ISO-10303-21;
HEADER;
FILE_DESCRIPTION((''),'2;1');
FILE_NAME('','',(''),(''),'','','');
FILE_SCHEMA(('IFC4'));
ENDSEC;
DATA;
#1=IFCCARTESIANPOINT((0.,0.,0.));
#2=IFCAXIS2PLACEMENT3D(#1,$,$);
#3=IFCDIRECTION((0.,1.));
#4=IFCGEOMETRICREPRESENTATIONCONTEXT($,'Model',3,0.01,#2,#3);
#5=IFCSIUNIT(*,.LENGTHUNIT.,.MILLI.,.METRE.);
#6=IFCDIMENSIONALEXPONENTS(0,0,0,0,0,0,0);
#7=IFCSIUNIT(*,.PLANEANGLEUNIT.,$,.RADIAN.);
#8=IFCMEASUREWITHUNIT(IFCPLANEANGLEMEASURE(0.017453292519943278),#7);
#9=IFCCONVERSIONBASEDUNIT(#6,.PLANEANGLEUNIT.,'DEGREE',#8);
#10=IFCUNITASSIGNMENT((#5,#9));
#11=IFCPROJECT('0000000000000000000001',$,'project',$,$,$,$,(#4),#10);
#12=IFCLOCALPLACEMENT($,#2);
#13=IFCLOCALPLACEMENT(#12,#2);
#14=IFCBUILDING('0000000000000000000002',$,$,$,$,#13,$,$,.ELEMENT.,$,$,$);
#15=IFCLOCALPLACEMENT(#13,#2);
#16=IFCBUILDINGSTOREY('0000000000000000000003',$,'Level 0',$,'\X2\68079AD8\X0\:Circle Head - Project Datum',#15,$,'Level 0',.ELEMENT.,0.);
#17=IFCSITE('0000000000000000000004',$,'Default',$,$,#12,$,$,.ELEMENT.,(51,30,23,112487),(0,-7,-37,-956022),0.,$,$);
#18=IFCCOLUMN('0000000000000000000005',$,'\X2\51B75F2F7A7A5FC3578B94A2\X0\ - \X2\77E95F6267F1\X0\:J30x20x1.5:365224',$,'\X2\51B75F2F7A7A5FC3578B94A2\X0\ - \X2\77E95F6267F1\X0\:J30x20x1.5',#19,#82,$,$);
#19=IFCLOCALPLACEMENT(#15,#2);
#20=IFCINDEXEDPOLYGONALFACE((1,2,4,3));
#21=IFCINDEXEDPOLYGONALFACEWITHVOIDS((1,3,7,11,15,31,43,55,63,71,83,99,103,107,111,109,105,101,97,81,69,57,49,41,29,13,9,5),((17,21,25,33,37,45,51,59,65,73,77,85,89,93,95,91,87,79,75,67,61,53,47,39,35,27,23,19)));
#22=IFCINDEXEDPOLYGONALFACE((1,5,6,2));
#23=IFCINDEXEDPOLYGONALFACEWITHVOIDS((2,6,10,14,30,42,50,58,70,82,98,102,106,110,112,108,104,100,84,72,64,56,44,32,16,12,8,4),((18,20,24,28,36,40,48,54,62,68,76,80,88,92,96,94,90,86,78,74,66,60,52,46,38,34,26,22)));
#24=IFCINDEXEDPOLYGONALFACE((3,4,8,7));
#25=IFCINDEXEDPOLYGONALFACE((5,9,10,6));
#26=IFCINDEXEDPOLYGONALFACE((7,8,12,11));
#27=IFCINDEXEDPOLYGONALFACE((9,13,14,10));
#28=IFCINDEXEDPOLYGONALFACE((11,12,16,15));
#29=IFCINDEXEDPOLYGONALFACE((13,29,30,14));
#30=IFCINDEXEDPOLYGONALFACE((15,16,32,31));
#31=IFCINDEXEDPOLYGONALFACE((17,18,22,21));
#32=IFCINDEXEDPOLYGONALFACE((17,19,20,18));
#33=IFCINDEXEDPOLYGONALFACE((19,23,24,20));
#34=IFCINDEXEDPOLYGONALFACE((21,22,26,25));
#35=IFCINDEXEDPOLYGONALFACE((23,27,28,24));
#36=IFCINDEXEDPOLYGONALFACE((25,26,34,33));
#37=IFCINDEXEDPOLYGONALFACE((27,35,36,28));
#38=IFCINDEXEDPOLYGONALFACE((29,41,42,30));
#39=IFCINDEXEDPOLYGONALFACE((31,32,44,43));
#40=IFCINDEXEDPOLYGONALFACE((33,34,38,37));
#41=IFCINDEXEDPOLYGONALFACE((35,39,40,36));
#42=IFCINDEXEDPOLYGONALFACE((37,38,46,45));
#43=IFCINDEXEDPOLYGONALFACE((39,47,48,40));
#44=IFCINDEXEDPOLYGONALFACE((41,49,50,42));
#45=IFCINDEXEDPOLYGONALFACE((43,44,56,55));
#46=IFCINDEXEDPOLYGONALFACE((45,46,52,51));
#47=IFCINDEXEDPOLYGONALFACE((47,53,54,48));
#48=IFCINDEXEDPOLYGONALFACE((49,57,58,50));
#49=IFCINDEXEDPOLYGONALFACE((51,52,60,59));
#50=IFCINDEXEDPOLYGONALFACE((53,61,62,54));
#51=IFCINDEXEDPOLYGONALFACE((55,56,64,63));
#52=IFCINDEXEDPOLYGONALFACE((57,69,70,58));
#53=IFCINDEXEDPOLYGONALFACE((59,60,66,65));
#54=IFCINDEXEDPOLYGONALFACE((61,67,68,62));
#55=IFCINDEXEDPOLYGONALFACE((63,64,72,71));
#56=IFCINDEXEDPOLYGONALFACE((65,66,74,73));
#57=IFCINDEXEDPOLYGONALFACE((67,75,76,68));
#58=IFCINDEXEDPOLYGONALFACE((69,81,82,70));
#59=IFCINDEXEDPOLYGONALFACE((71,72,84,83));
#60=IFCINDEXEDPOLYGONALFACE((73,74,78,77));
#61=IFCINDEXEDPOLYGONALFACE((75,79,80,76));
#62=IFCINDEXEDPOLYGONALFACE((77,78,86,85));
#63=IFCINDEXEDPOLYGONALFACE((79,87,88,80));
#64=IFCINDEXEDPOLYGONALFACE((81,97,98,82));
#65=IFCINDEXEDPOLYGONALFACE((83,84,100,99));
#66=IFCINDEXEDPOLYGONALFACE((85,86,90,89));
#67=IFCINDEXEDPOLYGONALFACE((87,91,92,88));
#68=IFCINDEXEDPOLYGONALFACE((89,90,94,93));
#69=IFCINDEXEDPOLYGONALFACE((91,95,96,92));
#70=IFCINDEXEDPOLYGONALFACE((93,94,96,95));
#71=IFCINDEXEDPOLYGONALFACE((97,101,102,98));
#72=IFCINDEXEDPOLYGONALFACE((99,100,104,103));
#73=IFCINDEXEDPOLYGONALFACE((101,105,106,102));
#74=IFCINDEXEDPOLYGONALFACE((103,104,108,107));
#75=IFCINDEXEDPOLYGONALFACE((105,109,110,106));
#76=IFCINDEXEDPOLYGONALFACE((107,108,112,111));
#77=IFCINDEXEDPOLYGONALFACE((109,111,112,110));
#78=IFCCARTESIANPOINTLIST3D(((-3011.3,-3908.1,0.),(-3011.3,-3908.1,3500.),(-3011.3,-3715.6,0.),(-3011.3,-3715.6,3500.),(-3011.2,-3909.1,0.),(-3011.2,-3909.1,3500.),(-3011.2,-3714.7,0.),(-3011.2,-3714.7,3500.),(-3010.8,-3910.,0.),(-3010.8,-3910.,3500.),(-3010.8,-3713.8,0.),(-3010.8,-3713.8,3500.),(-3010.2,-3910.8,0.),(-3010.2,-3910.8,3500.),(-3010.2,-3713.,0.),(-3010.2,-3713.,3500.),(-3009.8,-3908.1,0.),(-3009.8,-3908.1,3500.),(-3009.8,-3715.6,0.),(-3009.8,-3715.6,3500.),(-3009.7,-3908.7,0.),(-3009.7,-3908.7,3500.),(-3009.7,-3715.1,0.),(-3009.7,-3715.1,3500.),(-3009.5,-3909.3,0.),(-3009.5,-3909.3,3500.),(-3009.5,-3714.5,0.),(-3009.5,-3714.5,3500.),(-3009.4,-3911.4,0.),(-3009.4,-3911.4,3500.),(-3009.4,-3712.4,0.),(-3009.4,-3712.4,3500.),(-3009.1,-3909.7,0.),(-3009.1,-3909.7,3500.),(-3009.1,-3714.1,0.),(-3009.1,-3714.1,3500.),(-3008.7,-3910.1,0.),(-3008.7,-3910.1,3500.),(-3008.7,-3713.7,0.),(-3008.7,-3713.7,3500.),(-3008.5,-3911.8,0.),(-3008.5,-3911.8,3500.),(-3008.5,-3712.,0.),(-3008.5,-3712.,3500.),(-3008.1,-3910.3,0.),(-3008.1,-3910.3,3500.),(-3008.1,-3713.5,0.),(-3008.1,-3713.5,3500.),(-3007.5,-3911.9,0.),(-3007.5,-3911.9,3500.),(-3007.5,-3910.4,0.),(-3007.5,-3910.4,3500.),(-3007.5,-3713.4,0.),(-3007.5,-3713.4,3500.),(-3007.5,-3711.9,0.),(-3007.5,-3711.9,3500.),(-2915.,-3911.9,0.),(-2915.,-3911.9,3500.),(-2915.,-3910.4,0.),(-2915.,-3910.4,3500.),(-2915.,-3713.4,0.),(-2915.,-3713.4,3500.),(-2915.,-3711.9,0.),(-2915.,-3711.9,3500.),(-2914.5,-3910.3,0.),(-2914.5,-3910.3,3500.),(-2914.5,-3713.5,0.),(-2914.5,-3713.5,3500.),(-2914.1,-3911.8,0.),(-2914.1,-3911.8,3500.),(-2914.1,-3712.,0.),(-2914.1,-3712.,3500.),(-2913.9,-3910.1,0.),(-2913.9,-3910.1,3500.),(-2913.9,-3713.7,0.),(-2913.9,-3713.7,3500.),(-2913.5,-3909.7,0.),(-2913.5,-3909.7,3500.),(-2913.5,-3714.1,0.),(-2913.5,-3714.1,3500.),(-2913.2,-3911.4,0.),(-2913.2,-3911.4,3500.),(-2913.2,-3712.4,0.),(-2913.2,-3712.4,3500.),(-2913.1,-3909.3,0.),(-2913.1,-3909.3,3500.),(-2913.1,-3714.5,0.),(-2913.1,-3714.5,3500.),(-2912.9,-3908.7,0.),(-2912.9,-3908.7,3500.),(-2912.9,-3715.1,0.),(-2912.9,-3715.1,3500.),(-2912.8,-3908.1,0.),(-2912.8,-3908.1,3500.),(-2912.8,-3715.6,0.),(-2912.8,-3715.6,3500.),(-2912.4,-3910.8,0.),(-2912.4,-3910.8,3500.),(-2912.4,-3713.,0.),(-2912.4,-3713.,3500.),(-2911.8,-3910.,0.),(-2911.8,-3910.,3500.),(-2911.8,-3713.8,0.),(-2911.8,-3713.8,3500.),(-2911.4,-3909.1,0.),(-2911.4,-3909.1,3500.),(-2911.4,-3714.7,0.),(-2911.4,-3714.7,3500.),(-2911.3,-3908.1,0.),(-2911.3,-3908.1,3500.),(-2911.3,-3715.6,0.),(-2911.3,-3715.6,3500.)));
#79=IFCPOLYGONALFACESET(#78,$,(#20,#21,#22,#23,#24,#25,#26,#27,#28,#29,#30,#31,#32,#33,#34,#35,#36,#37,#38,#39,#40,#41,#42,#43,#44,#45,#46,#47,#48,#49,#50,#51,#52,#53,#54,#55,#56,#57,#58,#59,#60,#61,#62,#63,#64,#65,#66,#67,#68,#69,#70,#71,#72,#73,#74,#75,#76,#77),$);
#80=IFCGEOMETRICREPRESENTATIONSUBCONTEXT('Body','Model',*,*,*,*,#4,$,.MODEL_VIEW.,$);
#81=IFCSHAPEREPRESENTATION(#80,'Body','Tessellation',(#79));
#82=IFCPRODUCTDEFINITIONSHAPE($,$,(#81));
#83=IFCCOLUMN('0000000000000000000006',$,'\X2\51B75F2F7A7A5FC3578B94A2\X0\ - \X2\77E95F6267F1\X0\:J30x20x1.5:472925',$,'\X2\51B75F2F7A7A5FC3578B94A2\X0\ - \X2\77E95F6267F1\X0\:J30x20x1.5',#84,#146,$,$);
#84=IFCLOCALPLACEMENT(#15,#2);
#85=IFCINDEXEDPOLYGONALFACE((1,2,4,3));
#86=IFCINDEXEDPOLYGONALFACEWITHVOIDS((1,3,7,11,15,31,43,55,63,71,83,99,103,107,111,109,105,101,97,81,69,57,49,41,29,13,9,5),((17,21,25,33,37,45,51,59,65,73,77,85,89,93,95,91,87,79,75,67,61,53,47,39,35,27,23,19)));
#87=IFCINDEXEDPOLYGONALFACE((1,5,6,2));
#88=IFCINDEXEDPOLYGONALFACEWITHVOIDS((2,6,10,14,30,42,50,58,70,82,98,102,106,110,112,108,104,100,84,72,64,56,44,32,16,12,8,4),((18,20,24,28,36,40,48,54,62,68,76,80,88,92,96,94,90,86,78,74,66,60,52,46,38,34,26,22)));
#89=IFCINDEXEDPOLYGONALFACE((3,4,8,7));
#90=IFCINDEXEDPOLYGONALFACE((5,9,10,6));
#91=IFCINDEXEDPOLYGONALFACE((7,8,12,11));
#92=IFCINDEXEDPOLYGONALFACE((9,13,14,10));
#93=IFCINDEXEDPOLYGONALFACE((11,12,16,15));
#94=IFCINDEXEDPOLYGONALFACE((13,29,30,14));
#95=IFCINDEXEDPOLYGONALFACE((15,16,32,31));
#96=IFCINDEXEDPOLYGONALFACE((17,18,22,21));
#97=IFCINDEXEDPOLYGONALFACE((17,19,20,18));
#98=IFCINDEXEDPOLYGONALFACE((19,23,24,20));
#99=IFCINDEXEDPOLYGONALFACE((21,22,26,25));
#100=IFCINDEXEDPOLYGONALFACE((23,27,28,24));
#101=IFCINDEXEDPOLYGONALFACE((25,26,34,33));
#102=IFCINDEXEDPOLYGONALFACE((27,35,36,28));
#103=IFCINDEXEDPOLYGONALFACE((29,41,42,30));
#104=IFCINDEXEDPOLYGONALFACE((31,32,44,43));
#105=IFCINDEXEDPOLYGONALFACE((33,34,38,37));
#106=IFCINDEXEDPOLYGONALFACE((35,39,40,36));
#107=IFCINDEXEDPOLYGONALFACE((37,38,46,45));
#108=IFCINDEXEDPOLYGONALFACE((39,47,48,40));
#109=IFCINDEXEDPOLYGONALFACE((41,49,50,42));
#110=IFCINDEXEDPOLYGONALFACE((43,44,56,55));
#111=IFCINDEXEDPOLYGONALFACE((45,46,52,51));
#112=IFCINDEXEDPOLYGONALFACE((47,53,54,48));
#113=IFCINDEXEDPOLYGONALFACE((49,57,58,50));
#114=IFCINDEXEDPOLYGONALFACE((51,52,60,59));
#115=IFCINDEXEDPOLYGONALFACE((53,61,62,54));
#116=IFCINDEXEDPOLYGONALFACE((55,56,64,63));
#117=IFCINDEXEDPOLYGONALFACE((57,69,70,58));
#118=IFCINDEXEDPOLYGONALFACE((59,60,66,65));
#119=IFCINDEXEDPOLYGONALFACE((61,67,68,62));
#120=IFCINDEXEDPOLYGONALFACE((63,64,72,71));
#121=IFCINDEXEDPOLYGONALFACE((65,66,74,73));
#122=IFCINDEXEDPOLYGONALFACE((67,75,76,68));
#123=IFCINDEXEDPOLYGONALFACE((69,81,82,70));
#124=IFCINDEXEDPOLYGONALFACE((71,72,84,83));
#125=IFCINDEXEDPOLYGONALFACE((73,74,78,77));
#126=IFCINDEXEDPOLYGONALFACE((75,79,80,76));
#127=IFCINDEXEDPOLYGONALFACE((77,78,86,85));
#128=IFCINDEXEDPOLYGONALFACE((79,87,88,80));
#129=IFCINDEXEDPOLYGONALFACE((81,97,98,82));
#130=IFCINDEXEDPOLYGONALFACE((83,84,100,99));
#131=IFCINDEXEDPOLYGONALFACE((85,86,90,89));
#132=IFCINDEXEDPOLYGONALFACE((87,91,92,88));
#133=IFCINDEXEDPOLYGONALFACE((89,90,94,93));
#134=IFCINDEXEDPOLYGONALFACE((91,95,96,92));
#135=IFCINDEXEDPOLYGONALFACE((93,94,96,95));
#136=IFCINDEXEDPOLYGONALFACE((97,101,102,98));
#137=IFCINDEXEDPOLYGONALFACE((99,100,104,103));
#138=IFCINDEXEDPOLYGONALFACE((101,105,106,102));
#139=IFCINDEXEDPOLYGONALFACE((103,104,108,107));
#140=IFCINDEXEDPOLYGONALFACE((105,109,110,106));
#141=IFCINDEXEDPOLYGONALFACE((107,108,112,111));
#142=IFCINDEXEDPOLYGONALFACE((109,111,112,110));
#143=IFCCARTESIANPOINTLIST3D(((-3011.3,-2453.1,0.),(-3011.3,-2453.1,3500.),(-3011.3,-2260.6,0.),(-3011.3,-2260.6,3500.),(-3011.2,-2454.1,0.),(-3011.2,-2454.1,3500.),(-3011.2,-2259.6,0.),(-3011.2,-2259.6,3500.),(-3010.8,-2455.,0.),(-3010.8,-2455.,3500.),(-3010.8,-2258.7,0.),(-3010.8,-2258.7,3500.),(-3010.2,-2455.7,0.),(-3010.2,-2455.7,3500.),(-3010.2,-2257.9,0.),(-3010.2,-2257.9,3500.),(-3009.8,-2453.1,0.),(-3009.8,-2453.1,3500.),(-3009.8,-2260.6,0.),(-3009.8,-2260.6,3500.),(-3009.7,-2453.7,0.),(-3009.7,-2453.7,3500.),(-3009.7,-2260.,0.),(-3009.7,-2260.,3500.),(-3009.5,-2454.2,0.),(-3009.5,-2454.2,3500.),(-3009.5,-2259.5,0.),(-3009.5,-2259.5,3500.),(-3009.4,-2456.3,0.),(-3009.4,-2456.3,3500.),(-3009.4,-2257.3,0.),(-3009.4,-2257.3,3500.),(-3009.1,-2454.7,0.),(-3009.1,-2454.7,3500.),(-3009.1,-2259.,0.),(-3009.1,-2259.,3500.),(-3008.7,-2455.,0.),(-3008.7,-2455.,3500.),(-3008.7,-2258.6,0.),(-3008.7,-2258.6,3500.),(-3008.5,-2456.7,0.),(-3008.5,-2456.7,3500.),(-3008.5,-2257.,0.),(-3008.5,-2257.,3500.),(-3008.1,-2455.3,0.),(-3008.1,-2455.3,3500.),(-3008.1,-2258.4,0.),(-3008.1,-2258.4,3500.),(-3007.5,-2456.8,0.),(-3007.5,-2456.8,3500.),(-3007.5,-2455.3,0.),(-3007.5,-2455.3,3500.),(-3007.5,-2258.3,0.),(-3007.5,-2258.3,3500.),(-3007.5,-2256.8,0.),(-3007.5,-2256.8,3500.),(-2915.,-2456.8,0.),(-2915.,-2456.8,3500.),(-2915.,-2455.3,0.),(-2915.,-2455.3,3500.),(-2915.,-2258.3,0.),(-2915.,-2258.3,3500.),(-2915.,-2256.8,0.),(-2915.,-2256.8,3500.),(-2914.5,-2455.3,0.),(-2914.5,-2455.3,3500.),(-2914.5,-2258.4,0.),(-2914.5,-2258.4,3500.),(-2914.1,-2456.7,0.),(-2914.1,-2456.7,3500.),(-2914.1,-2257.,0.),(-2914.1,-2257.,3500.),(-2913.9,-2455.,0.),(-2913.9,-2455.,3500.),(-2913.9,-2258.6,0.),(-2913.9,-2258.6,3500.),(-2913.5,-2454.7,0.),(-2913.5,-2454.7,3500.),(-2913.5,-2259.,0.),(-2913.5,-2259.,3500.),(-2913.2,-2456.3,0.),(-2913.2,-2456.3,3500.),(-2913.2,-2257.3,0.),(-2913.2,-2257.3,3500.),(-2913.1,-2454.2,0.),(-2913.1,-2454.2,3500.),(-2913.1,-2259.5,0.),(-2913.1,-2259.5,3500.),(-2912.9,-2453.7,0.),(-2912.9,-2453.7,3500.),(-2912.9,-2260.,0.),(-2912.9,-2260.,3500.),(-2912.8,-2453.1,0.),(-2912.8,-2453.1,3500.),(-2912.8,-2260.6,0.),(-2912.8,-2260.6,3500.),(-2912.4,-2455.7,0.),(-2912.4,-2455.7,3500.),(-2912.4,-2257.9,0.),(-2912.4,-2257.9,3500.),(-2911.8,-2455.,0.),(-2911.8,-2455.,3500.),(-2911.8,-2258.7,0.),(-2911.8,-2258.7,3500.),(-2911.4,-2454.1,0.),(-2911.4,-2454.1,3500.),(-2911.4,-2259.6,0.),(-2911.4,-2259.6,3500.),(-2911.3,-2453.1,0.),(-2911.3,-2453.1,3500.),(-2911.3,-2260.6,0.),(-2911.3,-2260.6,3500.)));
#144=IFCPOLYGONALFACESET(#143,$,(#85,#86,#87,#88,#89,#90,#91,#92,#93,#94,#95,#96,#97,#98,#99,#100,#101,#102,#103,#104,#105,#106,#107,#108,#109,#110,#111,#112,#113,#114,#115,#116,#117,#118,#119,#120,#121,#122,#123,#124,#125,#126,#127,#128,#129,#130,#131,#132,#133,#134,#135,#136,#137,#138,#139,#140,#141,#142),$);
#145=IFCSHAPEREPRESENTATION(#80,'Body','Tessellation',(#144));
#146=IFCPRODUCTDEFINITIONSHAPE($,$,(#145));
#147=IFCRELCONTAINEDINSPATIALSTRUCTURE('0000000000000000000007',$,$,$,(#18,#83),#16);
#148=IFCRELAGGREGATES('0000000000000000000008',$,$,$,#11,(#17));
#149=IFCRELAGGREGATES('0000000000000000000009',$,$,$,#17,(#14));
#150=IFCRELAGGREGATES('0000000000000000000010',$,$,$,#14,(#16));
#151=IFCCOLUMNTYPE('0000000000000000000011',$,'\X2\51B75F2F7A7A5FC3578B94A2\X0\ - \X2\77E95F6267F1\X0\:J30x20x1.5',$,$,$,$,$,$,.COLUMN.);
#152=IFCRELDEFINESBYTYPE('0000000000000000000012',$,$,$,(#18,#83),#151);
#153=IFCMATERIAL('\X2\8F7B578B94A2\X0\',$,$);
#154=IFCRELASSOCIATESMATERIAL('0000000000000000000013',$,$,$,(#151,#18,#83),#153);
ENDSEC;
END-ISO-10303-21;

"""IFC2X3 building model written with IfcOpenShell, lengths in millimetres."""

from ifc_helpers import new_model, entity, si_unit, converted_unit, direction, frame, frame_2d, origin, place, context, subcontext, project, spatial, polyline, circle_curve, parameter, trimmed, segment, composite_curve, outline, extrude, source, transform, mapped, material, type_object, type_shapes, element, save


model = new_model("IFC2X3")

# Units and contexts
model_context = context("Model", 3, precision=0.01, world=origin(), true_north=direction((0.0, 1.0)))
body_context = subcontext(model_context, "Body", "Model", "MODEL_VIEW")
ifc_project = project(units=[si_unit("LENGTHUNIT", "METRE", prefix="MILLI"), converted_unit("PLANEANGLEUNIT", "DEGREE", entity("IfcPlaneAngleMeasure", 0.017453292519943278), si_unit("PLANEANGLEUNIT", "RADIAN"), dimensions=[0, 0, 0, 0, 0, 0, 0])], contexts=[model_context])

# Site, building, storey
site_placement = place(None, origin())
site = spatial("IfcSite", under=ifc_project, at=site_placement, Name="Default", CompositionType="ELEMENT", RefLatitude=(51, 30, 23, 112487), RefLongitude=(0, -7, -37, -956022), RefElevation=0.0)
building_placement = place(site_placement, origin())
building = spatial("IfcBuilding", under=site, at=building_placement, CompositionType="ELEMENT")
storey_placement = place(building_placement, origin())
storey = spatial("IfcBuildingStorey", under=building, at=storey_placement, Name="Level 0", ObjectType="标高:Circle Head - Project Datum", LongName="Level 0", CompositionType="ELEMENT", Elevation=0.0)

# Columns
ifc_material_1 = material(Name="轻型钢")
column_type = type_object("IfcColumnType", Name="冷弯空心型钢 - 矩形柱:J30x20x1.5", PredefinedType="COLUMN", material=ifc_material_1)
shared_shape = source(origin(), body_context, "Body", "SweptSolid", [
    extrude(outline(composite_curve([segment(polyline([(-46.2, -100.0), (46.3, -100.0)]), True, "CONTINUOUS"), segment(trimmed(circle_curve(frame_2d((46.3, -96.3), x_axis=(-1.0, 0.0)), 3.8), [parameter(90.0)], [parameter(180.0)], True, "PARAMETER"), True, "CONTINUOUS"), segment(polyline([(50.0, -96.3), (50.0, 96.3)]), True, "CONTINUOUS"), segment(trimmed(circle_curve(frame_2d((46.2, 96.3), x_axis=(-1.0, 0.0)), 3.8), [parameter(180.0)], [parameter(270.0)], True, "PARAMETER"), True, "CONTINUOUS"), segment(polyline([(46.2, 100.0), (-46.2, 100.0)]), True, "CONTINUOUS"), segment(trimmed(circle_curve(frame_2d((-46.2, 96.3), x_axis=(-1.0, 0.0)), 3.8), [parameter(270.0)], [parameter(0.0)], True, "PARAMETER"), True, "CONTINUOUS"), segment(polyline([(-50.0, 96.3), (-50.0, -96.3)]), True, "CONTINUOUS"), segment(trimmed(circle_curve(frame_2d((-46.2, -96.3), x_axis=(-1.0, 0.0)), 3.8), [parameter(360.0)], [parameter(90.0)], True, "PARAMETER"), True, "CONTINUOUS")], self_intersect=False), holes=[composite_curve([segment(trimmed(circle_curve(frame_2d((-46.3, -96.3), x_axis=(-1.0, 0.0)), 2.2), [parameter(0.0)], [parameter(90.0)], True, "PARAMETER"), False, "CONTINUOUS"), segment(polyline([(-48.5, -96.3), (-48.5, 96.3)]), True, "CONTINUOUS"), segment(trimmed(circle_curve(frame_2d((-46.3, 96.3), x_axis=(-1.0, 0.0)), 2.2), [parameter(270.0)], [parameter(0.0)], True, "PARAMETER"), False, "CONTINUOUS"), segment(polyline([(-46.3, 98.5), (46.2, 98.5)]), True, "CONTINUOUS"), segment(trimmed(circle_curve(frame_2d((46.2, 96.3), x_axis=(-1.0, 0.0)), 2.2), [parameter(180.0)], [parameter(270.0)], True, "PARAMETER"), False, "CONTINUOUS"), segment(polyline([(48.5, 96.3), (48.5, -96.3)]), True, "CONTINUOUS"), segment(trimmed(circle_curve(frame_2d((46.3, -96.3), x_axis=(-1.0, 0.0)), 2.2), [parameter(90.0)], [parameter(180.0)], True, "PARAMETER"), False, "CONTINUOUS"), segment(polyline([(46.3, -98.5), (-46.3, -98.5)]), True, "CONTINUOUS")], self_intersect=False)]), frame((0.0, 0.0, 0.0), z_axis=(0.0, 0.0, 1.0), x_axis=(-1.0, 0.0, 0.0)), (0.0, 0.0, 1.0), 3500.0),
])
type_shapes(column_type, [shared_shape])
for number, where, z_axis, x_axis, name in (
    (1, (-2961.3, -3811.9, 0.0), (0.0, 0.0, 1.0), (-1.0, 0.0, 0.0), "冷弯空心型钢 - 矩形柱:J30x20x1.5:365224"),
    (2, (-2961.3, -2356.8, 0.0), (0.0, 0.0, 1.0), (-1.0, 0.0, 0.0), "冷弯空心型钢 - 矩形柱:J30x20x1.5:472925"),
):
    element("IfcColumn", number, at=place(storey_placement, frame(where, z_axis=z_axis, x_axis=x_axis)), inside=storey, type_object=column_type, material=ifc_material_1, Name=name, ObjectType="冷弯空心型钢 - 矩形柱:J30x20x1.5", context=body_context, shape_type="MappedRepresentation", body=[
        mapped(shared_shape, transform((0.0, 0.0, 0.0), scale=1.0)),
    ])

save(model, "model.ifc")
